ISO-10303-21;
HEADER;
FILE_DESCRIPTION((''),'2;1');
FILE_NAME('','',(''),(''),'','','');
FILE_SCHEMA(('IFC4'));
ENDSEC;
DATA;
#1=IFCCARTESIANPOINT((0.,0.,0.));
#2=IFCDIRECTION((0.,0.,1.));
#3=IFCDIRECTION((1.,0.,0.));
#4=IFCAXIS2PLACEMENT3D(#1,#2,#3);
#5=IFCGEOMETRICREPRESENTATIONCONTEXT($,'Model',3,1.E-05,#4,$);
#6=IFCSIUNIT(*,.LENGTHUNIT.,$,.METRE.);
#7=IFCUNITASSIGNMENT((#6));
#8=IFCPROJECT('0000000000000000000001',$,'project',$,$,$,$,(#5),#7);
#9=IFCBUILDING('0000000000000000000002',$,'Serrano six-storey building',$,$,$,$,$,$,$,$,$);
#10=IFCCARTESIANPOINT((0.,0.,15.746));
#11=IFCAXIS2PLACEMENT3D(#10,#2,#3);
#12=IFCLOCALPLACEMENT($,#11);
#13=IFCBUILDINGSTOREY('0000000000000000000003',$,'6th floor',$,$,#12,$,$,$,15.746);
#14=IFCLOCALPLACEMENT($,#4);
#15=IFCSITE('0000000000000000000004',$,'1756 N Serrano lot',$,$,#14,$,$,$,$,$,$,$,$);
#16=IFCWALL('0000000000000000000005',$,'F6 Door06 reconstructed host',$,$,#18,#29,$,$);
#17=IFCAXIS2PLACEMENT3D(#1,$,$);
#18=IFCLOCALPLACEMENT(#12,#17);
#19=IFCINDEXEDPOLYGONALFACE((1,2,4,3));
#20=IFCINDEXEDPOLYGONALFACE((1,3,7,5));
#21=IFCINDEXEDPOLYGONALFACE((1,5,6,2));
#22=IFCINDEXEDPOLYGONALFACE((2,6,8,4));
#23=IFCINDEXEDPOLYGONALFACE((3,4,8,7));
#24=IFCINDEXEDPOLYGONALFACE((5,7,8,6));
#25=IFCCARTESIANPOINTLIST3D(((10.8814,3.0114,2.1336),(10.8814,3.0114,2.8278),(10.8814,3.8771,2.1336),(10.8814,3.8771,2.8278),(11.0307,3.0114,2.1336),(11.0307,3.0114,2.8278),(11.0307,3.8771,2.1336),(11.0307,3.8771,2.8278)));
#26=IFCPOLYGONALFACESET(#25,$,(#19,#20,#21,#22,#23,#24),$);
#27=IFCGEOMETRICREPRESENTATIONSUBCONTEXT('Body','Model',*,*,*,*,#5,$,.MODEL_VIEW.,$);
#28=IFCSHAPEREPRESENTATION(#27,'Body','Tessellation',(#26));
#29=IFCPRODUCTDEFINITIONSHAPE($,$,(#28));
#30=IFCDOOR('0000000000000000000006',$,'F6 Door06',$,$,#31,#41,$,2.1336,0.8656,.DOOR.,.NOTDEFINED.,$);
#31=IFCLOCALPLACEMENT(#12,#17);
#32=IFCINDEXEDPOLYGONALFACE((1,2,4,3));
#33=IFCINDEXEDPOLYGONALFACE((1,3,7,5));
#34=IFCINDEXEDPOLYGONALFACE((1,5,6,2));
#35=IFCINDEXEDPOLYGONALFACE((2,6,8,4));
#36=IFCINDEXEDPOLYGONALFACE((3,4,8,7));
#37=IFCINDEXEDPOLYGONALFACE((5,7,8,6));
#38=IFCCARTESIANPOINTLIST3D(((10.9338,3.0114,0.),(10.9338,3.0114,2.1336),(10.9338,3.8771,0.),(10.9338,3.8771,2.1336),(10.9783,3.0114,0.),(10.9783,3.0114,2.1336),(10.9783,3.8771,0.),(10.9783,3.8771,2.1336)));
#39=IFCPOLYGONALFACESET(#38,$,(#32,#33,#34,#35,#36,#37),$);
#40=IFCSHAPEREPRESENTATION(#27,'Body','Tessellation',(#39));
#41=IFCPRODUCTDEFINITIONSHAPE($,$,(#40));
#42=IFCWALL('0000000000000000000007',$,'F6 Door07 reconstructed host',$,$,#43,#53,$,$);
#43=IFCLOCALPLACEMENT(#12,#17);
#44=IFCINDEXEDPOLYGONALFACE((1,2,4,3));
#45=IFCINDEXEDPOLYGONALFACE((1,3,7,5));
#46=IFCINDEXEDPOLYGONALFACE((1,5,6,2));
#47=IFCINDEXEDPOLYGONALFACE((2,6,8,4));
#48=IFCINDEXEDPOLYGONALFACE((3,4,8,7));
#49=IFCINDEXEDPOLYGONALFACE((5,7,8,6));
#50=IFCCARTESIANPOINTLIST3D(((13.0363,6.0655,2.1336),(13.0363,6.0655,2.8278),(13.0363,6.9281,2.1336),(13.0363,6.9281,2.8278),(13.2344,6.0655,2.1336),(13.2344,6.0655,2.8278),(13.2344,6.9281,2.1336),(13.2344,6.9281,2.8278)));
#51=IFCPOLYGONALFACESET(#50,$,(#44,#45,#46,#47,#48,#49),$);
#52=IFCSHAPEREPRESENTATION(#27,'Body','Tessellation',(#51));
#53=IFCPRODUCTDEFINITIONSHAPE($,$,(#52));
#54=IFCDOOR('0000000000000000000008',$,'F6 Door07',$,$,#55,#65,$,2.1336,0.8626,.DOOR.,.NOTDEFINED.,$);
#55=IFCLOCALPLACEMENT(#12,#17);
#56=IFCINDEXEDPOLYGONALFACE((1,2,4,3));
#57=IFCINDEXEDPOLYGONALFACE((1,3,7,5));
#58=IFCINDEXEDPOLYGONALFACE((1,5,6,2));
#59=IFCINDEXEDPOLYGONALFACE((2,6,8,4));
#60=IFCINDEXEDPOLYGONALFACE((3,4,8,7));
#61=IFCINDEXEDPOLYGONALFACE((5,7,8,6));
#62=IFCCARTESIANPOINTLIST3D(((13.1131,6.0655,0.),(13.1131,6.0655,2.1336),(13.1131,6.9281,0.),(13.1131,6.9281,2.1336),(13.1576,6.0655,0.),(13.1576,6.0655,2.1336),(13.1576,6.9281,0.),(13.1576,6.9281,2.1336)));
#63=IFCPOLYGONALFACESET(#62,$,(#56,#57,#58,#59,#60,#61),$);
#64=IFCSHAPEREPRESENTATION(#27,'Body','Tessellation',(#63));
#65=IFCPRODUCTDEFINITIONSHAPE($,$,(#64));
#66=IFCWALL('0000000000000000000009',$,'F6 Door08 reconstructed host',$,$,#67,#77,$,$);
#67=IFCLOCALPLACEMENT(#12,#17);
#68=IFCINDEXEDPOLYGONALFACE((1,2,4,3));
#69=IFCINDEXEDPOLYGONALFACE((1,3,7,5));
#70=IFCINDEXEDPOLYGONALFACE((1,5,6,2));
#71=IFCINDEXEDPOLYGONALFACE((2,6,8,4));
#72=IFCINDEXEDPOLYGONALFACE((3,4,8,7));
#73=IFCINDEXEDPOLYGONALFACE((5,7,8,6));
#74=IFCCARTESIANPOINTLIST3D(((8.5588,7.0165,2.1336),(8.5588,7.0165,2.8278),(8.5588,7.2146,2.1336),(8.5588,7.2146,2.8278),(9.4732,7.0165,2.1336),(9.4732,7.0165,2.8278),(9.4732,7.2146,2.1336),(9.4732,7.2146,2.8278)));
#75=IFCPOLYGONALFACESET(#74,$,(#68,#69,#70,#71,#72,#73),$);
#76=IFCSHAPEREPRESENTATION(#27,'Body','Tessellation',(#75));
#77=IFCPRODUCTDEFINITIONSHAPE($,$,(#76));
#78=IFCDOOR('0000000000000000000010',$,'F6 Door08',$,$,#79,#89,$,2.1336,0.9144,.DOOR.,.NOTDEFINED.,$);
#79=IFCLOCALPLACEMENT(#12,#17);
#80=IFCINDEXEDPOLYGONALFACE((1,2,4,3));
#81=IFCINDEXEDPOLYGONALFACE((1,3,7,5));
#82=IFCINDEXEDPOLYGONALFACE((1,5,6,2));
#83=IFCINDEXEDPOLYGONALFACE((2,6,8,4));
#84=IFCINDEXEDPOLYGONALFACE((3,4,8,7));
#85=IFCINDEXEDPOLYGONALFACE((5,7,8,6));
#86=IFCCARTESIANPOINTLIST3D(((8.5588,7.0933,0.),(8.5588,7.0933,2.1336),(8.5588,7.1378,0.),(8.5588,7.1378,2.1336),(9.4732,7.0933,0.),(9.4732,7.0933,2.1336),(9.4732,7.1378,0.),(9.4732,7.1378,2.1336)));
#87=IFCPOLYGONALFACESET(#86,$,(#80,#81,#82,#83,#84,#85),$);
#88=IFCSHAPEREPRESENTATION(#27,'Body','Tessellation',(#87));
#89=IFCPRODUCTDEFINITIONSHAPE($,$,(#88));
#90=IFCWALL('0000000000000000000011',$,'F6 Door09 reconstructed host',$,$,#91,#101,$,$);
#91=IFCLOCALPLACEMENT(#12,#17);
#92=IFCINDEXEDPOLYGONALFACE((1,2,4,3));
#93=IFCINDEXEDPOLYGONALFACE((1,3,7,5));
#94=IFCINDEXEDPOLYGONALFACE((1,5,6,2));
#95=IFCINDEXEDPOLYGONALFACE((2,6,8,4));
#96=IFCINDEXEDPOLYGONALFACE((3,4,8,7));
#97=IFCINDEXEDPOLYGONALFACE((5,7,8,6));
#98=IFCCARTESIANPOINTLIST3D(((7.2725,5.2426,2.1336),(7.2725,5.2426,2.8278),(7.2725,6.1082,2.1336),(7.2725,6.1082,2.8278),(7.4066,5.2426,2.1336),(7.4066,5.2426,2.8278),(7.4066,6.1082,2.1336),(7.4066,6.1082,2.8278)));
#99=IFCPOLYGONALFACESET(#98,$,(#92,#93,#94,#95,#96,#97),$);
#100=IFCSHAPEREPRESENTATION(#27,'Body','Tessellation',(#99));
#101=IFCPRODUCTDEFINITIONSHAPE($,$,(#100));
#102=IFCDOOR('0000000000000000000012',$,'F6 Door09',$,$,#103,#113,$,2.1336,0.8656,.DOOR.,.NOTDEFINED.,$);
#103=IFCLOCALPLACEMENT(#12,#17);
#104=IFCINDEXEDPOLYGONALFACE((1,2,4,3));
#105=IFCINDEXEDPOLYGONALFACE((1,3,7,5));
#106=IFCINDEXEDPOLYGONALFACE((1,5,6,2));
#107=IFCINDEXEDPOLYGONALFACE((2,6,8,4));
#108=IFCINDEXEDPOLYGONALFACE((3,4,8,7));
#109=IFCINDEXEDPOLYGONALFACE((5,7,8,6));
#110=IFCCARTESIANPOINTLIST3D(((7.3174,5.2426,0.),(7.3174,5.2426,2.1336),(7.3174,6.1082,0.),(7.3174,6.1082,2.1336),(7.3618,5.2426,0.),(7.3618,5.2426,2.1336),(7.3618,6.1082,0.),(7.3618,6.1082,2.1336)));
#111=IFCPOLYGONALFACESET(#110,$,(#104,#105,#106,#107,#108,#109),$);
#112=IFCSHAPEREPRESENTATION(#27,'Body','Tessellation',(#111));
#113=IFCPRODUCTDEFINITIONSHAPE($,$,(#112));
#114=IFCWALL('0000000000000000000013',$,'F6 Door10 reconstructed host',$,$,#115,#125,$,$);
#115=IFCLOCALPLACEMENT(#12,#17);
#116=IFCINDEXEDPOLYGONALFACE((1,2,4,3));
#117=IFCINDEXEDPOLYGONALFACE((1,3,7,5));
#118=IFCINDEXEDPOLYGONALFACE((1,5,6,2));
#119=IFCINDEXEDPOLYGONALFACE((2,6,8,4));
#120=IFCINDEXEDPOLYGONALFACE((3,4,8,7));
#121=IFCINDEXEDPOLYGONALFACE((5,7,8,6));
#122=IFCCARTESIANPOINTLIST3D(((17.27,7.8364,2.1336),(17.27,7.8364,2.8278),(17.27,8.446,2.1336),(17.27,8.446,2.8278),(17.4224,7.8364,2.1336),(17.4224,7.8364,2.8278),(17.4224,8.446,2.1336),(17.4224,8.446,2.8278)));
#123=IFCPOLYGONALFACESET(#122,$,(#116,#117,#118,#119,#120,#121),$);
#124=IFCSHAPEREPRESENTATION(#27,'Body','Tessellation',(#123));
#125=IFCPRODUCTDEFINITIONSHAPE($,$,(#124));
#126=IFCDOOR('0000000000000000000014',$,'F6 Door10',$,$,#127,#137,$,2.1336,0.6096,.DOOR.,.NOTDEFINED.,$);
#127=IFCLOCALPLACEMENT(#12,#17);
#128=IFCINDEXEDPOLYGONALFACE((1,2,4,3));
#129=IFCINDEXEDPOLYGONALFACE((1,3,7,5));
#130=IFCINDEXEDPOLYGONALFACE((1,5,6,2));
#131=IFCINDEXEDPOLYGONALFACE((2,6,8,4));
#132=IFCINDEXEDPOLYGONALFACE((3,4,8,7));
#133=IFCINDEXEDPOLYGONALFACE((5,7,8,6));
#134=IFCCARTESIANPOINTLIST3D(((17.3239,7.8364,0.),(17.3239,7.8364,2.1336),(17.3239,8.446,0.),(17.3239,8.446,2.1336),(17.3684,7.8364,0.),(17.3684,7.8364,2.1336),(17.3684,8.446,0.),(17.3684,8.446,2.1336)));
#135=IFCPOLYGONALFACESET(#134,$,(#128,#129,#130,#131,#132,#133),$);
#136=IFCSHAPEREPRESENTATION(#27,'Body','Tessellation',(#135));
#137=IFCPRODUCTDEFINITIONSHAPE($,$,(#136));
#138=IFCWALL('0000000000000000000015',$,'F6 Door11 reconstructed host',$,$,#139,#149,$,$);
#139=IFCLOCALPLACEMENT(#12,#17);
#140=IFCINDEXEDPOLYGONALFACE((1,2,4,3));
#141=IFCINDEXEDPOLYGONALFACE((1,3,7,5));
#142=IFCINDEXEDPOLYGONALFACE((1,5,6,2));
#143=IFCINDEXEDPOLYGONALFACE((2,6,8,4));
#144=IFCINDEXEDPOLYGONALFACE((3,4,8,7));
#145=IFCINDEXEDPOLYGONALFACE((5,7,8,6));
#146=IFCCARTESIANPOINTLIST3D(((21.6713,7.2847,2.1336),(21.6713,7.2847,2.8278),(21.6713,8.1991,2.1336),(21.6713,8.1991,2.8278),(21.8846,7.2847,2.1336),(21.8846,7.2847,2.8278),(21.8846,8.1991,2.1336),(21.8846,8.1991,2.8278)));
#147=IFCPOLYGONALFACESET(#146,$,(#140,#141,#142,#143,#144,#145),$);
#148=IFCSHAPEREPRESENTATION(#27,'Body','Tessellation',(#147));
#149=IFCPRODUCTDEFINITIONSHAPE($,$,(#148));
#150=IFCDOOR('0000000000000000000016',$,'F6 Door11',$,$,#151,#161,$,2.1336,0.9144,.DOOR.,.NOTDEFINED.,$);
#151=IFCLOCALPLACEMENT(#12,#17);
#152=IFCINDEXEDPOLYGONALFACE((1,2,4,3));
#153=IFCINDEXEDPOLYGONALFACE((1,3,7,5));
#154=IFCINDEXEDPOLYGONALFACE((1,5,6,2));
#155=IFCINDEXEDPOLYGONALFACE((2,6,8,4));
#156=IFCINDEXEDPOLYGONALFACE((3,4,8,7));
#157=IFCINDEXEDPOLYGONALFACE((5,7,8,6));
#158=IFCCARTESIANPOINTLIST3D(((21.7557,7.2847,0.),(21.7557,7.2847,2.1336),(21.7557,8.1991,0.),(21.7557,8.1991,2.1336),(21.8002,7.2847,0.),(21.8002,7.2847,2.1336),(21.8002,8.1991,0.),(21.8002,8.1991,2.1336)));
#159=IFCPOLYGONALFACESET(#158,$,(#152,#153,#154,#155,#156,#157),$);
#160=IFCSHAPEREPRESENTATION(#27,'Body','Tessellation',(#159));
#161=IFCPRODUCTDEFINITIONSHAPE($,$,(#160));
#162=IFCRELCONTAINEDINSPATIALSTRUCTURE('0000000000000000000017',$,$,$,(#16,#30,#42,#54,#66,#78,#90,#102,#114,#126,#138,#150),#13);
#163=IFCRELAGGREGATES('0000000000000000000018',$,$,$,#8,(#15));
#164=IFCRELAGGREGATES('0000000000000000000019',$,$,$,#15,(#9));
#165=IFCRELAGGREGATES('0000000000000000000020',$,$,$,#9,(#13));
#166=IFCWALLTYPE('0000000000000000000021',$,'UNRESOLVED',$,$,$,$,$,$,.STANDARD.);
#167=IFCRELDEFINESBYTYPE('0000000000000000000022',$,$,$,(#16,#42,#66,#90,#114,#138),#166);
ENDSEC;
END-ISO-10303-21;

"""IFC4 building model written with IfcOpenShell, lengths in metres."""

from ifc_helpers import new_model, si_unit, frame, origin_with_axes, place, context, subcontext, project, spatial, polyline, outline, extrude, type_object, element, fill, save


model = new_model("IFC4")

# Units and contexts
model_context = context("Model", 3, precision=1e-05, world=origin_with_axes())
body_context = subcontext(model_context, "Body", "Model", "MODEL_VIEW")
ifc_project = project(units=[si_unit("LENGTHUNIT", "METRE")], contexts=[model_context])

# Site, building, storey
site_placement = place(None, origin_with_axes())
site = spatial("IfcSite", under=ifc_project, at=site_placement, Name="1756 N Serrano lot")
building = spatial("IfcBuilding", under=site, Name="Serrano six-storey building")
storey_placement = place(None, frame((0.0, 0.0, 15.746), z_axis=(0.0, 0.0, 1.0), x_axis=(1.0, 0.0, 0.0)))
storey = spatial("IfcBuildingStorey", under=building, at=storey_placement, Name="6th floor", Elevation=15.746)

# Shared definitions
wall_type = type_object("IfcWallType", Name="UNRESOLVED", PredefinedType="STANDARD")

# Walls, openings, doors
wall_1_placement = place(storey_placement, frame((0.0, 0.0, -15.746), z_axis=(0.0, 0.0, 1.0), x_axis=(1.0, 0.0, 0.0)))
wall_1 = element("IfcWall", 1, at=wall_1_placement, inside=storey, type_object=wall_type, Name="F6 Door06 reconstructed host", context=body_context, shape_type="SweptSolid", body=[
    extrude(outline(polyline([(10.8814, 3.8771), (11.0307, 3.8771), (11.0307, 3.0114), (10.8814, 3.0114), (10.8814, 3.8771)])), frame((0.0, 0.0, 15.746)), (0.0, 0.0, 1.0), 2.8278),
])
opening_1_placement = place(None, origin_with_axes())
opening_1 = element("IfcOpeningElement", 2, at=opening_1_placement, cuts=wall_1, PredefinedType="OPENING", context=body_context, shape_type="SweptSolid", body=[
    extrude(outline(polyline([(10.8631, 3.8771), (11.049, 3.8771), (11.049, 3.0114), (10.8631, 3.0114), (10.8631, 3.8771)])), frame((0.0, 0.0, 15.746)), (0.0, 0.0, 1.0), 2.1336),
])
door_1_placement = place(storey_placement, frame((0.0, 0.0, -15.746), z_axis=(0.0, 0.0, 1.0), x_axis=(1.0, 0.0, 0.0)))
door_1 = element("IfcDoor", 3, at=door_1_placement, inside=storey, Name="F6 Door06", OperationType="NOTDEFINED", OverallHeight=2.1336, OverallWidth=0.8656, PredefinedType="DOOR", context=body_context, shape_type="SweptSolid", body=[
    extrude(outline(polyline([(10.9338, 3.8771), (10.9783, 3.8771), (10.9783, 3.0114), (10.9338, 3.0114), (10.9338, 3.8771)])), frame((0.0, 0.0, 15.746)), (0.0, 0.0, 1.0), 2.1336),
])
fill(opening_1, door_1)
wall_2_placement = place(storey_placement, frame((0.0, 0.0, -15.746), z_axis=(0.0, 0.0, 1.0), x_axis=(1.0, 0.0, 0.0)))
wall_2 = element("IfcWall", 4, at=wall_2_placement, inside=storey, type_object=wall_type, Name="F6 Door07 reconstructed host", context=body_context, shape_type="SweptSolid", body=[
    extrude(outline(polyline([(13.2344, 6.0655), (13.0363, 6.0655), (13.0363, 6.9281), (13.2344, 6.9281), (13.2344, 6.0655)])), frame((0.0, 0.0, 15.746)), (0.0, 0.0, 1.0), 2.8278),
])
opening_2_placement = place(None, origin_with_axes())
opening_2 = element("IfcOpeningElement", 5, at=opening_2_placement, cuts=wall_2, PredefinedType="OPENING", context=body_context, shape_type="SweptSolid", body=[
    extrude(outline(polyline([(13.2527, 6.0655), (13.018, 6.0655), (13.018, 6.9281), (13.2527, 6.9281), (13.2527, 6.0655)])), frame((0.0, 0.0, 15.746)), (0.0, 0.0, 1.0), 2.1336),
])
door_2_placement = place(storey_placement, frame((0.0, 0.0, -15.746), z_axis=(0.0, 0.0, 1.0), x_axis=(1.0, 0.0, 0.0)))
door_2 = element("IfcDoor", 6, at=door_2_placement, inside=storey, Name="F6 Door07", OperationType="NOTDEFINED", OverallHeight=2.1336, OverallWidth=0.8626, PredefinedType="DOOR", context=body_context, shape_type="SweptSolid", body=[
    extrude(outline(polyline([(13.1576, 6.0655), (13.1131, 6.0655), (13.1131, 6.9281), (13.1576, 6.9281), (13.1576, 6.0655)])), frame((0.0, 0.0, 15.746)), (0.0, 0.0, 1.0), 2.1336),
])
fill(opening_2, door_2)
wall_3_placement = place(storey_placement, frame((0.0, 0.0, -15.746), z_axis=(0.0, 0.0, 1.0), x_axis=(1.0, 0.0, 0.0)))
wall_3 = element("IfcWall", 7, at=wall_3_placement, inside=storey, type_object=wall_type, Name="F6 Door08 reconstructed host", context=body_context, shape_type="SweptSolid", body=[
    extrude(outline(polyline([(9.4732, 7.2146), (9.4732, 7.0165), (8.5588, 7.0165), (8.5588, 7.2146), (9.4732, 7.2146)])), frame((0.0, 0.0, 15.746)), (0.0, 0.0, 1.0), 2.8278),
])
opening_3_placement = place(None, origin_with_axes())
opening_3 = element("IfcOpeningElement", 8, at=opening_3_placement, cuts=wall_3, PredefinedType="OPENING", context=body_context, shape_type="SweptSolid", body=[
    extrude(outline(polyline([(9.4732, 7.2329), (9.4732, 6.9982), (8.5588, 6.9982), (8.5588, 7.2329), (9.4732, 7.2329)])), frame((0.0, 0.0, 15.746)), (0.0, 0.0, 1.0), 2.1336),
])
door_3_placement = place(storey_placement, frame((0.0, 0.0, -15.746), z_axis=(0.0, 0.0, 1.0), x_axis=(1.0, 0.0, 0.0)))
door_3 = element("IfcDoor", 9, at=door_3_placement, inside=storey, Name="F6 Door08", OperationType="NOTDEFINED", OverallHeight=2.1336, OverallWidth=0.9144, PredefinedType="DOOR", context=body_context, shape_type="SweptSolid", body=[
    extrude(outline(polyline([(9.4732, 7.1378), (9.4732, 7.0933), (8.5588, 7.0933), (8.5588, 7.1378), (9.4732, 7.1378)])), frame((0.0, 0.0, 15.746)), (0.0, 0.0, 1.0), 2.1336),
])
fill(opening_3, door_3)
wall_4_placement = place(storey_placement, frame((0.0, 0.0, -15.746), z_axis=(0.0, 0.0, 1.0), x_axis=(1.0, 0.0, 0.0)))
wall_4 = element("IfcWall", 10, at=wall_4_placement, inside=storey, type_object=wall_type, Name="F6 Door09 reconstructed host", context=body_context, shape_type="SweptSolid", body=[
    extrude(outline(polyline([(7.4066, 5.2426), (7.2725, 5.2426), (7.2725, 6.1082), (7.4066, 6.1082), (7.4066, 5.2426)])), frame((0.0, 0.0, 15.746)), (0.0, 0.0, 1.0), 2.8278),
])
opening_4_placement = place(None, origin_with_axes())
opening_4 = element("IfcOpeningElement", 11, at=opening_4_placement, cuts=wall_4, PredefinedType="OPENING", context=body_context, shape_type="SweptSolid", body=[
    extrude(outline(polyline([(7.4249, 5.2426), (7.2542, 5.2426), (7.2542, 6.1082), (7.4249, 6.1082), (7.4249, 5.2426)])), frame((0.0, 0.0, 15.746)), (0.0, 0.0, 1.0), 2.1336),
])
door_4_placement = place(storey_placement, frame((0.0, 0.0, -15.746), z_axis=(0.0, 0.0, 1.0), x_axis=(1.0, 0.0, 0.0)))
door_4 = element("IfcDoor", 12, at=door_4_placement, inside=storey, Name="F6 Door09", OperationType="NOTDEFINED", OverallHeight=2.1336, OverallWidth=0.8656, PredefinedType="DOOR", context=body_context, shape_type="SweptSolid", body=[
    extrude(outline(polyline([(7.3618, 5.2426), (7.3174, 5.2426), (7.3174, 6.1082), (7.3618, 6.1082), (7.3618, 5.2426)])), frame((0.0, 0.0, 15.746)), (0.0, 0.0, 1.0), 2.1336),
])
fill(opening_4, door_4)
wall_5_placement = place(storey_placement, frame((0.0, 0.0, -15.746), z_axis=(0.0, 0.0, 1.0), x_axis=(1.0, 0.0, 0.0)))
wall_5 = element("IfcWall", 13, at=wall_5_placement, inside=storey, type_object=wall_type, Name="F6 Door10 reconstructed host", context=body_context, shape_type="SweptSolid", body=[
    extrude(outline(polyline([(17.4224, 7.8364), (17.27, 7.8364), (17.27, 8.446), (17.4224, 8.446), (17.4224, 7.8364)])), frame((0.0, 0.0, 15.746)), (0.0, 0.0, 1.0), 2.8278),
])
opening_5_placement = place(None, origin_with_axes())
opening_5 = element("IfcOpeningElement", 14, at=opening_5_placement, cuts=wall_5, PredefinedType="OPENING", context=body_context, shape_type="SweptSolid", body=[
    extrude(outline(polyline([(17.4407, 7.8364), (17.2517, 7.8364), (17.2517, 8.446), (17.4407, 8.446), (17.4407, 7.8364)])), frame((0.0, 0.0, 15.746)), (0.0, 0.0, 1.0), 2.1336),
])
door_5_placement = place(storey_placement, frame((0.0, 0.0, -15.746), z_axis=(0.0, 0.0, 1.0), x_axis=(1.0, 0.0, 0.0)))
door_5 = element("IfcDoor", 15, at=door_5_placement, inside=storey, Name="F6 Door10", OperationType="NOTDEFINED", OverallHeight=2.1336, OverallWidth=0.6096, PredefinedType="DOOR", context=body_context, shape_type="SweptSolid", body=[
    extrude(outline(polyline([(17.3684, 7.8364), (17.3239, 7.8364), (17.3239, 8.446), (17.3684, 8.446), (17.3684, 7.8364)])), frame((0.0, 0.0, 15.746)), (0.0, 0.0, 1.0), 2.1336),
])
fill(opening_5, door_5)
wall_6_placement = place(storey_placement, frame((0.0, 0.0, -15.746), z_axis=(0.0, 0.0, 1.0), x_axis=(1.0, 0.0, 0.0)))
wall_6 = element("IfcWall", 16, at=wall_6_placement, inside=storey, type_object=wall_type, Name="F6 Door11 reconstructed host", context=body_context, shape_type="SweptSolid", body=[
    extrude(outline(polyline([(21.6713, 8.1991), (21.8846, 8.1991), (21.8846, 7.2847), (21.6713, 7.2847), (21.6713, 8.1991)])), frame((0.0, 0.0, 15.746)), (0.0, 0.0, 1.0), 2.8278),
])
opening_6_placement = place(None, origin_with_axes())
opening_6 = element("IfcOpeningElement", 17, at=opening_6_placement, cuts=wall_6, PredefinedType="OPENING", context=body_context, shape_type="SweptSolid", body=[
    extrude(outline(polyline([(21.653, 8.1991), (21.9029, 8.1991), (21.9029, 7.2847), (21.653, 7.2847), (21.653, 8.1991)])), frame((0.0, 0.0, 15.746)), (0.0, 0.0, 1.0), 2.1336),
])
door_6_placement = place(storey_placement, frame((0.0, 0.0, -15.746), z_axis=(0.0, 0.0, 1.0), x_axis=(1.0, 0.0, 0.0)))
door_6 = element("IfcDoor", 18, at=door_6_placement, inside=storey, Name="F6 Door11", OperationType="NOTDEFINED", OverallHeight=2.1336, OverallWidth=0.9144, PredefinedType="DOOR", context=body_context, shape_type="SweptSolid", body=[
    extrude(outline(polyline([(21.7557, 8.1991), (21.8002, 8.1991), (21.8002, 7.2847), (21.7557, 7.2847), (21.7557, 8.1991)])), frame((0.0, 0.0, 15.746)), (0.0, 0.0, 1.0), 2.1336),
])
fill(opening_6, door_6)

save(model, "model.ifc")
